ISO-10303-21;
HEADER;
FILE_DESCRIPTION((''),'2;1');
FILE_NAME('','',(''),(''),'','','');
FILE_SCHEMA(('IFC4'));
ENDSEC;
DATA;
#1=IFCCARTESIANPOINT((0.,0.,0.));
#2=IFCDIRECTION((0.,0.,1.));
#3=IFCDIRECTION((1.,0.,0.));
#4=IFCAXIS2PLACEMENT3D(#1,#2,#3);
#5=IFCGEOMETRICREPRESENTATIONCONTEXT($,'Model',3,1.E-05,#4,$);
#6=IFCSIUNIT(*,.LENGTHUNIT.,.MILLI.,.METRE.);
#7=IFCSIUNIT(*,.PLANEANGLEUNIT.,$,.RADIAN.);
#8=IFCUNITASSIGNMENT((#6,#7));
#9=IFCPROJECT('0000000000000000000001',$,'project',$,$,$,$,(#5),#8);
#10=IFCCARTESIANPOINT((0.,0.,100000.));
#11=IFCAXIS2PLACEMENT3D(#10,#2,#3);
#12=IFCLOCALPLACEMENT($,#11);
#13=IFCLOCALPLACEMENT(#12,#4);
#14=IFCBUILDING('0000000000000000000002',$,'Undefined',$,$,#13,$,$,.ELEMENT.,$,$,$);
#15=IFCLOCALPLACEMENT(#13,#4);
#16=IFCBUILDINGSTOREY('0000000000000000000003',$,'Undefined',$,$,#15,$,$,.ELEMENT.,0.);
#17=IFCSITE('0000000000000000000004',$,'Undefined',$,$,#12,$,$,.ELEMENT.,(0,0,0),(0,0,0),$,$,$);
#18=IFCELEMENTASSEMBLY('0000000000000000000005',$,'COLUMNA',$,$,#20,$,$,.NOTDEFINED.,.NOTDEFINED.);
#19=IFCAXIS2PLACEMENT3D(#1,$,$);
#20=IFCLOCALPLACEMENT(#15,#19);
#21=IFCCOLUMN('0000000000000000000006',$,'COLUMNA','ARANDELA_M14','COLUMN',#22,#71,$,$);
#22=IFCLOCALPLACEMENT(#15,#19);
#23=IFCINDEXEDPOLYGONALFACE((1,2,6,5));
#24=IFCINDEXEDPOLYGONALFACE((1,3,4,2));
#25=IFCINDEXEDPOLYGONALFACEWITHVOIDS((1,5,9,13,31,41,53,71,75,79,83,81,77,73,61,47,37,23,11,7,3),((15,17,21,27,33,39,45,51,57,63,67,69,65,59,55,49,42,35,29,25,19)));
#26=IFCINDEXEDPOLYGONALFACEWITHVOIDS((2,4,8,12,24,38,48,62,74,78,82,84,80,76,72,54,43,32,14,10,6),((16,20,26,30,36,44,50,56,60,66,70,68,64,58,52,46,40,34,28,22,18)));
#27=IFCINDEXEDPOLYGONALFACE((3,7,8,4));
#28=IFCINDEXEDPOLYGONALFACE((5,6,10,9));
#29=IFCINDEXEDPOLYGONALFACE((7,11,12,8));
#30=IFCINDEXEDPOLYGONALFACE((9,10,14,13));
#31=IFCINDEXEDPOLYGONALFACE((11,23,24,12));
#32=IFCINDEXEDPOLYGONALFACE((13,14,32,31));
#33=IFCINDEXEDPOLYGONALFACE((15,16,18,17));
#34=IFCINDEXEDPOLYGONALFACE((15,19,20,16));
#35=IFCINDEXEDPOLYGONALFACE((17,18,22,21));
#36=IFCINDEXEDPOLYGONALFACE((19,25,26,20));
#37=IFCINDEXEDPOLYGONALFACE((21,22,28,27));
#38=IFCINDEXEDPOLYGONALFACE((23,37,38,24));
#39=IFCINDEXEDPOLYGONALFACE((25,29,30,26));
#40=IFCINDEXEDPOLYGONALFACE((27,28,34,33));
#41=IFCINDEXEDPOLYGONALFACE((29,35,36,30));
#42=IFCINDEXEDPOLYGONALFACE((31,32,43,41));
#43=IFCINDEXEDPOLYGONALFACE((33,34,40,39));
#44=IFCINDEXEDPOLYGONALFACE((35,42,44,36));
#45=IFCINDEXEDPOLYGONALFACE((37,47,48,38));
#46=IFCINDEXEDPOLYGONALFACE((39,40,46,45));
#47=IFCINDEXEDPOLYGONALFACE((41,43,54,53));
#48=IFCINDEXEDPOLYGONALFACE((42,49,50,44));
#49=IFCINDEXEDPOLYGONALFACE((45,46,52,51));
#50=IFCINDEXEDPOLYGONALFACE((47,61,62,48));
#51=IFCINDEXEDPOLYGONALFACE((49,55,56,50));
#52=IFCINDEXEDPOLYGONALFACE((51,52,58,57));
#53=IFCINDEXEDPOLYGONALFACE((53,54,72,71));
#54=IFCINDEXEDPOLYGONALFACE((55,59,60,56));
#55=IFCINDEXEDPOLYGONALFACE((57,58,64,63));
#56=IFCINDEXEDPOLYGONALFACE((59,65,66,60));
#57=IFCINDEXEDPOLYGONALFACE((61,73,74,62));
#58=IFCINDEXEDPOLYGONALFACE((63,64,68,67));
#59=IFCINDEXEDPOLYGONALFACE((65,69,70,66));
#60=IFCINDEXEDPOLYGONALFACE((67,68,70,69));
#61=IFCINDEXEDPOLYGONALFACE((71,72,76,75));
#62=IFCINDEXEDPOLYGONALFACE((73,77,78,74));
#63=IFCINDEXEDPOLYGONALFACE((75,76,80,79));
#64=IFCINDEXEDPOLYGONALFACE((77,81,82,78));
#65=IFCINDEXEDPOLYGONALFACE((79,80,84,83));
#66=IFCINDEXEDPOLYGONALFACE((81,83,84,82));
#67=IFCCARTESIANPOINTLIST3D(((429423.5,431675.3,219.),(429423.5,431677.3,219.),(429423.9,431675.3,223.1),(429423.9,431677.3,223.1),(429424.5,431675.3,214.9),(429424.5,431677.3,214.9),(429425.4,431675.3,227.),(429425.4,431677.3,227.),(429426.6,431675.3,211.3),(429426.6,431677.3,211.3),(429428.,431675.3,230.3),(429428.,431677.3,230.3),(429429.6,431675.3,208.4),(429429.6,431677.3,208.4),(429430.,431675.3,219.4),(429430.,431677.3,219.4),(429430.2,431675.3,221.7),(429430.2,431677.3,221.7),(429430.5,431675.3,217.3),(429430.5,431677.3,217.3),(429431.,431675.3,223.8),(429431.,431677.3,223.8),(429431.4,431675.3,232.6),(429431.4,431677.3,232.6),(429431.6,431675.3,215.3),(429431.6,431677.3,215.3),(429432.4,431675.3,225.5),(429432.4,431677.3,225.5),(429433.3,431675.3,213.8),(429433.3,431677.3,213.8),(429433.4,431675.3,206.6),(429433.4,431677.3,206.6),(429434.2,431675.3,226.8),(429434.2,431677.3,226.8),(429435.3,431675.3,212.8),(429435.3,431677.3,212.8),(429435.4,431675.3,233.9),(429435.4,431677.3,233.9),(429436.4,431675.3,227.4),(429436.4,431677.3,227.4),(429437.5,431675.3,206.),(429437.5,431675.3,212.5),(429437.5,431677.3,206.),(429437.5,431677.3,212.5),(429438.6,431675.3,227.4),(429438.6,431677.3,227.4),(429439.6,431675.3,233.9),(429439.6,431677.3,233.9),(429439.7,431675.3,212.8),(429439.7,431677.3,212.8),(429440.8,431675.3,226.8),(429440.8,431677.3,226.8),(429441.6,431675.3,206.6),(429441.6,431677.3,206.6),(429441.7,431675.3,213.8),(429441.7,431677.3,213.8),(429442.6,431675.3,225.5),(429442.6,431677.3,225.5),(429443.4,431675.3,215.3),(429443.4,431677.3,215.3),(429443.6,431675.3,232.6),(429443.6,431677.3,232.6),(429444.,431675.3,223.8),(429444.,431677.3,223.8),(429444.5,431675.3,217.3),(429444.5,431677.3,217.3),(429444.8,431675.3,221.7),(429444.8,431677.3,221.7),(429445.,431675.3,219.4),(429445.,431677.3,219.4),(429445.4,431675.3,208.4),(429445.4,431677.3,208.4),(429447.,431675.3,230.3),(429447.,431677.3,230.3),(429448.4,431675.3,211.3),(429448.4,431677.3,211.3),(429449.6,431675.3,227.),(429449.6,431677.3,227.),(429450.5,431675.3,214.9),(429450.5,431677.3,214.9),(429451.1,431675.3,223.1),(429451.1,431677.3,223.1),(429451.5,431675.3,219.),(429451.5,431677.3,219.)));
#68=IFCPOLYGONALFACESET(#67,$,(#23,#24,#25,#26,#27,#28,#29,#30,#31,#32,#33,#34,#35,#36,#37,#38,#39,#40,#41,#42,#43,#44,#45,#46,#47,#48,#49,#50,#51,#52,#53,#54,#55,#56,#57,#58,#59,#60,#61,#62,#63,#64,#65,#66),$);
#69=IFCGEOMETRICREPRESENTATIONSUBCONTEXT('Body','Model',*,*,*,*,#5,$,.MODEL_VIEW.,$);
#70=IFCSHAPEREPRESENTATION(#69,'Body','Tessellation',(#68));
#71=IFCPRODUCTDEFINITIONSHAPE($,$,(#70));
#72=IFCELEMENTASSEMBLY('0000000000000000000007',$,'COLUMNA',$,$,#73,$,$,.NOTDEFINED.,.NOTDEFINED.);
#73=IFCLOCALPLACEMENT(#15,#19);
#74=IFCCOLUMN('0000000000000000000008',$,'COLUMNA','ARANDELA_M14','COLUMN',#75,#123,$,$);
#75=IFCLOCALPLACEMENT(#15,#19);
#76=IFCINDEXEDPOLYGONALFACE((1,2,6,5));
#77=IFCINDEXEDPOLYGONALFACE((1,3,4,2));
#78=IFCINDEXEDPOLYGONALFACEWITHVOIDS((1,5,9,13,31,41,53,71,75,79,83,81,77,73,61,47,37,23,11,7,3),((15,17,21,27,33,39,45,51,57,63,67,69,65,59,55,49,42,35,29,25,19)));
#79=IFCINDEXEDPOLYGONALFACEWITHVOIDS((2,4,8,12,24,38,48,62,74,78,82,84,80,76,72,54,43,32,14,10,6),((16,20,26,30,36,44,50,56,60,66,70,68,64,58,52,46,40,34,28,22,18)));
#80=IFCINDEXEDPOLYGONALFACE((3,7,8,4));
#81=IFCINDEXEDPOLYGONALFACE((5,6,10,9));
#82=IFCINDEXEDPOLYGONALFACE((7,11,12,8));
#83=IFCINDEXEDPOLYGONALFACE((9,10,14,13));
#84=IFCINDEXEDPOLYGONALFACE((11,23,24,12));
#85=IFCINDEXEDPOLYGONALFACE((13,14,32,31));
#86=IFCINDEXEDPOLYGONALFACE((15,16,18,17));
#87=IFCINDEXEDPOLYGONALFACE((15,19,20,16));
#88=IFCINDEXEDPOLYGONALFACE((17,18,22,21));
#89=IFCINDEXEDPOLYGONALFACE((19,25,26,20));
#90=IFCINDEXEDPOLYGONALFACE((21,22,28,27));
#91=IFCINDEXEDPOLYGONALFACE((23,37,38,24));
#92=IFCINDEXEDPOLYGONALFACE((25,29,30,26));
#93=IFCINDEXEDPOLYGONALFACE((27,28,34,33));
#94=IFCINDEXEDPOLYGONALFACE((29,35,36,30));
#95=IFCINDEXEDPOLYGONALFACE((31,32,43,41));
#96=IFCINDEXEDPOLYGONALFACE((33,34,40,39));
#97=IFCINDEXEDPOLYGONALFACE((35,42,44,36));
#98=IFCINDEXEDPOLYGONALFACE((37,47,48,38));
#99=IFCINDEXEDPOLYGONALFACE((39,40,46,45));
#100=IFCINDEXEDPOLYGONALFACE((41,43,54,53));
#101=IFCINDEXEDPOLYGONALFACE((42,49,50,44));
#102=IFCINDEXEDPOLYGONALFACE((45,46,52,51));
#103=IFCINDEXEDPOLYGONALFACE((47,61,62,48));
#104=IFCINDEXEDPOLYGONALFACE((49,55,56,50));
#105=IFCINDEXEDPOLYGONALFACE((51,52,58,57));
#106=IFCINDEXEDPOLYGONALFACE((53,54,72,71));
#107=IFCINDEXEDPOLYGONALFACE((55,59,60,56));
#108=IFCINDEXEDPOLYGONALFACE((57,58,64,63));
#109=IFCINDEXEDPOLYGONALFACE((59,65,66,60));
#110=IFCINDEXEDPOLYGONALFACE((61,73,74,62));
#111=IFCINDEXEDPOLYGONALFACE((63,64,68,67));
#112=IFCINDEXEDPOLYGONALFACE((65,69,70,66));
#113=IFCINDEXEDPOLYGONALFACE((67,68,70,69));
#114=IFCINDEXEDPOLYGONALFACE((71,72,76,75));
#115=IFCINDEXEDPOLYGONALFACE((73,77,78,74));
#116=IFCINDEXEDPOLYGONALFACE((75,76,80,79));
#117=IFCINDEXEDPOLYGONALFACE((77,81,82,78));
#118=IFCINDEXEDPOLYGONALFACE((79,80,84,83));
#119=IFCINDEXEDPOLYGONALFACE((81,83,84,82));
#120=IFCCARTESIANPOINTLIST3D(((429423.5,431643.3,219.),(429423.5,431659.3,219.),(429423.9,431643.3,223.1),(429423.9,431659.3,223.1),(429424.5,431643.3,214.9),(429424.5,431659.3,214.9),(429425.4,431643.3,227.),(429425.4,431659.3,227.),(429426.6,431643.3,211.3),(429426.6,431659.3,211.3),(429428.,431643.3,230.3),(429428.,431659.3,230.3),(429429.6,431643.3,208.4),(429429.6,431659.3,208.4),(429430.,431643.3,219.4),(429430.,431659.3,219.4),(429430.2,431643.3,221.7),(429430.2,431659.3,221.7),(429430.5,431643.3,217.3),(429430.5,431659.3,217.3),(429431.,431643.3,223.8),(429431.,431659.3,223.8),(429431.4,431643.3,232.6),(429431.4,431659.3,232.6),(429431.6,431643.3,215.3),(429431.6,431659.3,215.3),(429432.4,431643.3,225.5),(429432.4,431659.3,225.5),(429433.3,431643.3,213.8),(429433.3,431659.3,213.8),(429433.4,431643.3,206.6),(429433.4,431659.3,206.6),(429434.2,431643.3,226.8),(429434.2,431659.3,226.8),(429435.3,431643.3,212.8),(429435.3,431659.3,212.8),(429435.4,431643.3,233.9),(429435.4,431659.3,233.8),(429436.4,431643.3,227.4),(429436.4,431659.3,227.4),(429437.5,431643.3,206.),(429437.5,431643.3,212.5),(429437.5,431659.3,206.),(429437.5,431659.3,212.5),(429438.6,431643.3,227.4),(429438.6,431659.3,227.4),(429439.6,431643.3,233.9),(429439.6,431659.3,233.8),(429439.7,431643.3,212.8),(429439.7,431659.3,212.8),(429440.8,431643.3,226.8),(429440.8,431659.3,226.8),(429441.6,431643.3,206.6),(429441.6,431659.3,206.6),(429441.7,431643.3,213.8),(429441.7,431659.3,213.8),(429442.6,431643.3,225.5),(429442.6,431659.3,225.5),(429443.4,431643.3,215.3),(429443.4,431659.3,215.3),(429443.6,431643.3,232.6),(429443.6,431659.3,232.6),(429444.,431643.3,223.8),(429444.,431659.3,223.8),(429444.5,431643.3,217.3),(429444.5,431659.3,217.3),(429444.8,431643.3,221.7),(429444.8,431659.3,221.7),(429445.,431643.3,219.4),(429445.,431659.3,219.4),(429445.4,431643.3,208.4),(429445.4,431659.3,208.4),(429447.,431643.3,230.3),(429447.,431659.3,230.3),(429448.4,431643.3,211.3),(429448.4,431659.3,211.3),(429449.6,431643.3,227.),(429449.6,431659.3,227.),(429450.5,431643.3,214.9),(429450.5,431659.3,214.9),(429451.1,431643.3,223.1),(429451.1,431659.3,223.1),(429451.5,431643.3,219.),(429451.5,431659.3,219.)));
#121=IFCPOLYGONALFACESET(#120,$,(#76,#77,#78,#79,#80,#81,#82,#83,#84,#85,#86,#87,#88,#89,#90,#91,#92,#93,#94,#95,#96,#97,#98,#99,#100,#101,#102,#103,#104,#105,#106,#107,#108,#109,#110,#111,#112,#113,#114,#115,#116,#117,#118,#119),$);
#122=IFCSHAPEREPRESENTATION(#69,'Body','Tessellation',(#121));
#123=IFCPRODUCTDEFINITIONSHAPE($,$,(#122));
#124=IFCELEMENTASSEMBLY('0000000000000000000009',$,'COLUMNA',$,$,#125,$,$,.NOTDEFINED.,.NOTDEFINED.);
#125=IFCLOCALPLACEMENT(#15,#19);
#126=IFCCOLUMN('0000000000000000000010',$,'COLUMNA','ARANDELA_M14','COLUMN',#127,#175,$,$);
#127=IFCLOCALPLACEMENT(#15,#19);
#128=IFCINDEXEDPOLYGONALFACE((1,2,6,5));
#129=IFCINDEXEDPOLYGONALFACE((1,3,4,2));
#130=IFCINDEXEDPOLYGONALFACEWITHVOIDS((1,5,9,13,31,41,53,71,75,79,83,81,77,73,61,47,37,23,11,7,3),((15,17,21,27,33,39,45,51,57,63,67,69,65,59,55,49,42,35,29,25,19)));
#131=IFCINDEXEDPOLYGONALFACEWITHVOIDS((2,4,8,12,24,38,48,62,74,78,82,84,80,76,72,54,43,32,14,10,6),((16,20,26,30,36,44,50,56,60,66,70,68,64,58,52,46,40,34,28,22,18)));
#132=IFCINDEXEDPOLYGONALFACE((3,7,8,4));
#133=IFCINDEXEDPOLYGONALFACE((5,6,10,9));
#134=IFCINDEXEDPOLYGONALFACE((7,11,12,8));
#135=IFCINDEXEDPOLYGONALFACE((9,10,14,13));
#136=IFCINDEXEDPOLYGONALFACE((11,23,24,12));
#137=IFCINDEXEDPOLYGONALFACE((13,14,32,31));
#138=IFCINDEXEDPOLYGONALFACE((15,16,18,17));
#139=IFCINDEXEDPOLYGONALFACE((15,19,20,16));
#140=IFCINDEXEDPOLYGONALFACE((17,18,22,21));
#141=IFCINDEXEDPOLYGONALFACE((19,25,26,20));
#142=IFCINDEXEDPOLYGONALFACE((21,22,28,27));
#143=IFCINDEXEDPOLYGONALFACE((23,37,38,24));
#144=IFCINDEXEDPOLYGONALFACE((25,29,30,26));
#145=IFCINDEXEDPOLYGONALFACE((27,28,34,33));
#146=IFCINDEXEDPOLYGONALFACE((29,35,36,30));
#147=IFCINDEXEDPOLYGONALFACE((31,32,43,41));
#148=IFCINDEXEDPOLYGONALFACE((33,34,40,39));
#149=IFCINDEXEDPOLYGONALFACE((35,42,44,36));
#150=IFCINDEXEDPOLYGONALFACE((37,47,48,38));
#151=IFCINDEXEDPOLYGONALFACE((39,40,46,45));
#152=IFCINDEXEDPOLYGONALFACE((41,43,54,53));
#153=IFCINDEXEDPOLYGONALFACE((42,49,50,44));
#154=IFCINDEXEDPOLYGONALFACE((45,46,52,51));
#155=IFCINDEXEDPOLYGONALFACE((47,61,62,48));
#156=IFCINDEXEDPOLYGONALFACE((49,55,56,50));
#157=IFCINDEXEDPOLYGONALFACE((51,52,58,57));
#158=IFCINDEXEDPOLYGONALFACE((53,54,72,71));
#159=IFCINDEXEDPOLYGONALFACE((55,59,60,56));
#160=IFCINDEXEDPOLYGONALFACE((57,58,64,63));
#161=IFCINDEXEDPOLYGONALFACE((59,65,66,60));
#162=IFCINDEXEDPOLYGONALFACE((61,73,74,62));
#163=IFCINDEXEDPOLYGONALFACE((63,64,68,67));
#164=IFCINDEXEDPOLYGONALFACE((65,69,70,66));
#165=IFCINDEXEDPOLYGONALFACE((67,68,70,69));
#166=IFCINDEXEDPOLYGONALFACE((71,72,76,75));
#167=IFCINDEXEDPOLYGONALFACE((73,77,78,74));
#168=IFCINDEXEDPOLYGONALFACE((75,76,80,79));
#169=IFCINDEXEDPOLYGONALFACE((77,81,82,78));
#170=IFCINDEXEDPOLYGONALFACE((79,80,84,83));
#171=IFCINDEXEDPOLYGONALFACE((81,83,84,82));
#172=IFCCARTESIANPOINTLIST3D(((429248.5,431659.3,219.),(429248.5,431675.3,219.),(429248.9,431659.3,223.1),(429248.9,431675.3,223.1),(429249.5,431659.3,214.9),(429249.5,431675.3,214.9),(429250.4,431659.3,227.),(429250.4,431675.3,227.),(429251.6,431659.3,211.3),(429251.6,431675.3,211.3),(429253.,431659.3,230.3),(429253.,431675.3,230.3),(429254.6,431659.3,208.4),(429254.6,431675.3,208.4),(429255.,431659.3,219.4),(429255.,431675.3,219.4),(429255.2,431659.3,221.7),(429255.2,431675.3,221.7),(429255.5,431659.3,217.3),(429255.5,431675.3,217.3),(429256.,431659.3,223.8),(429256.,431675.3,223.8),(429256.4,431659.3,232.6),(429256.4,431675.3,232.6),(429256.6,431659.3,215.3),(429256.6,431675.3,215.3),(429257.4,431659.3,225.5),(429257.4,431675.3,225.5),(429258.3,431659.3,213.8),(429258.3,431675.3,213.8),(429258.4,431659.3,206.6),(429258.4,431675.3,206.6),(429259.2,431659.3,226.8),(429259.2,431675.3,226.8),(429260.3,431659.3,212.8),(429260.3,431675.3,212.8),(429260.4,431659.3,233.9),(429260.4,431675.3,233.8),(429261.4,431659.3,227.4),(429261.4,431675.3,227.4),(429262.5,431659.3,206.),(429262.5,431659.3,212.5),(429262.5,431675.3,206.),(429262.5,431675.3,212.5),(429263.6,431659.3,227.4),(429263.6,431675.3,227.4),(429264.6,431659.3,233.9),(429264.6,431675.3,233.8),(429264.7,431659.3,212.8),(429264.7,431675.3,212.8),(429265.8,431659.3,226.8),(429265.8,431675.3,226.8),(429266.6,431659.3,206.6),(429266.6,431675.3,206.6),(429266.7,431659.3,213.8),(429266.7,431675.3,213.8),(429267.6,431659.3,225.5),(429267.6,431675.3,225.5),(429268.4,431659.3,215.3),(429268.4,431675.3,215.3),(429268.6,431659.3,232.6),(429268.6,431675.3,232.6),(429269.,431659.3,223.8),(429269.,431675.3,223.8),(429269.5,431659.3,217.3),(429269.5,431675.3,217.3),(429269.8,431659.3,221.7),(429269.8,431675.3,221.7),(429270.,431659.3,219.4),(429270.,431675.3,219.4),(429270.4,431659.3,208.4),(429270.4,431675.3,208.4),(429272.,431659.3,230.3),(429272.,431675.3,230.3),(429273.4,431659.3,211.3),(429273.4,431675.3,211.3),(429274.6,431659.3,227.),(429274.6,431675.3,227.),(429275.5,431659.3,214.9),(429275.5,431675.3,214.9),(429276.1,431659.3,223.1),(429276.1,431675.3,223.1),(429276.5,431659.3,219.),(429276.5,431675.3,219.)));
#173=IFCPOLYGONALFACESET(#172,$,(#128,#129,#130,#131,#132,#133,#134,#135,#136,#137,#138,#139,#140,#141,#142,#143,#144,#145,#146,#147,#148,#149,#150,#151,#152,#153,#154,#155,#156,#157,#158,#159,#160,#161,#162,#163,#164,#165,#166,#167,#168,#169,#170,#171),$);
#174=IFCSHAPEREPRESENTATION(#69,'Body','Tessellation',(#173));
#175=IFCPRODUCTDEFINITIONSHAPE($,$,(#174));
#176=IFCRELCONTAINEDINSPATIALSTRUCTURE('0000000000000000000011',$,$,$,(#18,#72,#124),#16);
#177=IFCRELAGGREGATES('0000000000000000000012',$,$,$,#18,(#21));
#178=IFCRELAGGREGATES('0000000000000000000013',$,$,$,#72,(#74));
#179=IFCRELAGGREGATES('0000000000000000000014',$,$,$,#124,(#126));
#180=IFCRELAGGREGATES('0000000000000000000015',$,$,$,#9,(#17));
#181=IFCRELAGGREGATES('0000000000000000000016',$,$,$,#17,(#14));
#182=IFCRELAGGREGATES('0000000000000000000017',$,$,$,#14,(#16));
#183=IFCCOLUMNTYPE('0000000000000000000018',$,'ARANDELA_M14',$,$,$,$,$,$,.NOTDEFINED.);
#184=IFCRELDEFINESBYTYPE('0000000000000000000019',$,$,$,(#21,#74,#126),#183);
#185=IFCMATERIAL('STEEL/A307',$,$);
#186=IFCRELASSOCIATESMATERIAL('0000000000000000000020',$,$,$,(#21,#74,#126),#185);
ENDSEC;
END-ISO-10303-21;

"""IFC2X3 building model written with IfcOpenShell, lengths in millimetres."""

from ifc_helpers import new_model, si_unit, frame, origin_with_axes, origin_2d_with_axis, place, context, subcontext, project, spatial, hollow_circle, extrude, material, type_object, element, aggregate, save


model = new_model("IFC2X3")

# Units and contexts
model_context = context("Model", 3, precision=1e-05, world=origin_with_axes())
body_context = subcontext(model_context, "Body", "Model", "MODEL_VIEW")
ifc_project = project(units=[si_unit("LENGTHUNIT", "METRE", prefix="MILLI"), si_unit("PLANEANGLEUNIT", "RADIAN")], contexts=[model_context])

# Site, building, storey
site_placement = place(None, frame((0.0, 0.0, 100000.0), z_axis=(0.0, 0.0, 1.0), x_axis=(1.0, 0.0, 0.0)))
site = spatial("IfcSite", under=ifc_project, at=site_placement, Name="Undefined", CompositionType="ELEMENT", RefLatitude=(0, 0, 0), RefLongitude=(0, 0, 0))
building_placement = place(site_placement, origin_with_axes())
building = spatial("IfcBuilding", under=site, at=building_placement, Name="Undefined", CompositionType="ELEMENT")
storey_placement = place(building_placement, origin_with_axes())
storey = spatial("IfcBuildingStorey", under=building, at=storey_placement, Name="Undefined", CompositionType="ELEMENT", Elevation=0.0)

# Element assemblies, columns
ifc_material_1 = material(Name="STEEL/A307")
column_type_1 = type_object("IfcColumnType", Name="ARANDELA_M14", PredefinedType="NOTDEFINED")
assembly_1_placement = place(storey_placement, origin_with_axes())
assembly_1 = element("IfcElementAssembly", 1, at=assembly_1_placement, inside=storey, Name="COLUMNA", AssemblyPlace="NOTDEFINED", PredefinedType="NOTDEFINED")
column_1_placement = place(assembly_1_placement, frame((429437.5, 431677.3, 220.0), z_axis=(0.0, -1.0, 0.000285), x_axis=(-1.0, 0.0, 0.0)))
column_1 = element("IfcColumn", 2, at=column_1_placement, type_object=column_type_1, material=ifc_material_1, Name="COLUMNA", Description="ARANDELA_M14", ObjectType="COLUMN", context=body_context, shape_type="SweptSolid", body=[
    extrude(hollow_circle(Radius=14.0, WallThickness=6.5, at=origin_2d_with_axis()), frame((0.0, 0.0, 2.0), z_axis=(0.0, 0.0, -1.0), x_axis=(0.0, 1.0, 0.0)), (0.0, 0.0, 1.0), 2.0),
])
aggregate(assembly_1, [column_1])
assembly_2_placement = place(storey_placement, origin_with_axes())
assembly_2 = element("IfcElementAssembly", 3, at=assembly_2_placement, inside=storey, Name="COLUMNA", AssemblyPlace="NOTDEFINED", PredefinedType="NOTDEFINED")
column_2_placement = place(assembly_2_placement, frame((429437.5, 431659.3, 220.0), z_axis=(0.0, -1.0, 0.000285), x_axis=(-1.0, 0.0, 0.0)))
column_2 = element("IfcColumn", 4, at=column_2_placement, type_object=column_type_1, material=ifc_material_1, Name="COLUMNA", Description="ARANDELA_M14", ObjectType="COLUMN", context=body_context, shape_type="SweptSolid", body=[
    extrude(hollow_circle(Radius=14.0, WallThickness=6.5, at=origin_2d_with_axis()), frame((0.0, 0.0, 16.0), z_axis=(0.0, 0.0, -1.0), x_axis=(0.0, 1.0, 0.0)), (0.0, 0.0, 1.0), 16.0),
])
aggregate(assembly_2, [column_2])
assembly_3_placement = place(storey_placement, origin_with_axes())
assembly_3 = element("IfcElementAssembly", 5, at=assembly_3_placement, inside=storey, Name="COLUMNA", AssemblyPlace="NOTDEFINED", PredefinedType="NOTDEFINED")
column_3_placement = place(assembly_3_placement, frame((429262.5, 431675.3, 220.0), z_axis=(0.0, -1.0, 0.000285), x_axis=(-1.0, 0.0, 0.0)))
column_3 = element("IfcColumn", 6, at=column_3_placement, type_object=column_type_1, material=ifc_material_1, Name="COLUMNA", Description="ARANDELA_M14", ObjectType="COLUMN", context=body_context, shape_type="SweptSolid", body=[
    extrude(hollow_circle(Radius=14.0, WallThickness=6.5, at=origin_2d_with_axis()), frame((0.0, 0.0, 16.0), z_axis=(0.0, 0.0, -1.0), x_axis=(0.0, 1.0, 0.0)), (0.0, 0.0, 1.0), 16.0),
])
aggregate(assembly_3, [column_3])

save(model, "model.ifc")
